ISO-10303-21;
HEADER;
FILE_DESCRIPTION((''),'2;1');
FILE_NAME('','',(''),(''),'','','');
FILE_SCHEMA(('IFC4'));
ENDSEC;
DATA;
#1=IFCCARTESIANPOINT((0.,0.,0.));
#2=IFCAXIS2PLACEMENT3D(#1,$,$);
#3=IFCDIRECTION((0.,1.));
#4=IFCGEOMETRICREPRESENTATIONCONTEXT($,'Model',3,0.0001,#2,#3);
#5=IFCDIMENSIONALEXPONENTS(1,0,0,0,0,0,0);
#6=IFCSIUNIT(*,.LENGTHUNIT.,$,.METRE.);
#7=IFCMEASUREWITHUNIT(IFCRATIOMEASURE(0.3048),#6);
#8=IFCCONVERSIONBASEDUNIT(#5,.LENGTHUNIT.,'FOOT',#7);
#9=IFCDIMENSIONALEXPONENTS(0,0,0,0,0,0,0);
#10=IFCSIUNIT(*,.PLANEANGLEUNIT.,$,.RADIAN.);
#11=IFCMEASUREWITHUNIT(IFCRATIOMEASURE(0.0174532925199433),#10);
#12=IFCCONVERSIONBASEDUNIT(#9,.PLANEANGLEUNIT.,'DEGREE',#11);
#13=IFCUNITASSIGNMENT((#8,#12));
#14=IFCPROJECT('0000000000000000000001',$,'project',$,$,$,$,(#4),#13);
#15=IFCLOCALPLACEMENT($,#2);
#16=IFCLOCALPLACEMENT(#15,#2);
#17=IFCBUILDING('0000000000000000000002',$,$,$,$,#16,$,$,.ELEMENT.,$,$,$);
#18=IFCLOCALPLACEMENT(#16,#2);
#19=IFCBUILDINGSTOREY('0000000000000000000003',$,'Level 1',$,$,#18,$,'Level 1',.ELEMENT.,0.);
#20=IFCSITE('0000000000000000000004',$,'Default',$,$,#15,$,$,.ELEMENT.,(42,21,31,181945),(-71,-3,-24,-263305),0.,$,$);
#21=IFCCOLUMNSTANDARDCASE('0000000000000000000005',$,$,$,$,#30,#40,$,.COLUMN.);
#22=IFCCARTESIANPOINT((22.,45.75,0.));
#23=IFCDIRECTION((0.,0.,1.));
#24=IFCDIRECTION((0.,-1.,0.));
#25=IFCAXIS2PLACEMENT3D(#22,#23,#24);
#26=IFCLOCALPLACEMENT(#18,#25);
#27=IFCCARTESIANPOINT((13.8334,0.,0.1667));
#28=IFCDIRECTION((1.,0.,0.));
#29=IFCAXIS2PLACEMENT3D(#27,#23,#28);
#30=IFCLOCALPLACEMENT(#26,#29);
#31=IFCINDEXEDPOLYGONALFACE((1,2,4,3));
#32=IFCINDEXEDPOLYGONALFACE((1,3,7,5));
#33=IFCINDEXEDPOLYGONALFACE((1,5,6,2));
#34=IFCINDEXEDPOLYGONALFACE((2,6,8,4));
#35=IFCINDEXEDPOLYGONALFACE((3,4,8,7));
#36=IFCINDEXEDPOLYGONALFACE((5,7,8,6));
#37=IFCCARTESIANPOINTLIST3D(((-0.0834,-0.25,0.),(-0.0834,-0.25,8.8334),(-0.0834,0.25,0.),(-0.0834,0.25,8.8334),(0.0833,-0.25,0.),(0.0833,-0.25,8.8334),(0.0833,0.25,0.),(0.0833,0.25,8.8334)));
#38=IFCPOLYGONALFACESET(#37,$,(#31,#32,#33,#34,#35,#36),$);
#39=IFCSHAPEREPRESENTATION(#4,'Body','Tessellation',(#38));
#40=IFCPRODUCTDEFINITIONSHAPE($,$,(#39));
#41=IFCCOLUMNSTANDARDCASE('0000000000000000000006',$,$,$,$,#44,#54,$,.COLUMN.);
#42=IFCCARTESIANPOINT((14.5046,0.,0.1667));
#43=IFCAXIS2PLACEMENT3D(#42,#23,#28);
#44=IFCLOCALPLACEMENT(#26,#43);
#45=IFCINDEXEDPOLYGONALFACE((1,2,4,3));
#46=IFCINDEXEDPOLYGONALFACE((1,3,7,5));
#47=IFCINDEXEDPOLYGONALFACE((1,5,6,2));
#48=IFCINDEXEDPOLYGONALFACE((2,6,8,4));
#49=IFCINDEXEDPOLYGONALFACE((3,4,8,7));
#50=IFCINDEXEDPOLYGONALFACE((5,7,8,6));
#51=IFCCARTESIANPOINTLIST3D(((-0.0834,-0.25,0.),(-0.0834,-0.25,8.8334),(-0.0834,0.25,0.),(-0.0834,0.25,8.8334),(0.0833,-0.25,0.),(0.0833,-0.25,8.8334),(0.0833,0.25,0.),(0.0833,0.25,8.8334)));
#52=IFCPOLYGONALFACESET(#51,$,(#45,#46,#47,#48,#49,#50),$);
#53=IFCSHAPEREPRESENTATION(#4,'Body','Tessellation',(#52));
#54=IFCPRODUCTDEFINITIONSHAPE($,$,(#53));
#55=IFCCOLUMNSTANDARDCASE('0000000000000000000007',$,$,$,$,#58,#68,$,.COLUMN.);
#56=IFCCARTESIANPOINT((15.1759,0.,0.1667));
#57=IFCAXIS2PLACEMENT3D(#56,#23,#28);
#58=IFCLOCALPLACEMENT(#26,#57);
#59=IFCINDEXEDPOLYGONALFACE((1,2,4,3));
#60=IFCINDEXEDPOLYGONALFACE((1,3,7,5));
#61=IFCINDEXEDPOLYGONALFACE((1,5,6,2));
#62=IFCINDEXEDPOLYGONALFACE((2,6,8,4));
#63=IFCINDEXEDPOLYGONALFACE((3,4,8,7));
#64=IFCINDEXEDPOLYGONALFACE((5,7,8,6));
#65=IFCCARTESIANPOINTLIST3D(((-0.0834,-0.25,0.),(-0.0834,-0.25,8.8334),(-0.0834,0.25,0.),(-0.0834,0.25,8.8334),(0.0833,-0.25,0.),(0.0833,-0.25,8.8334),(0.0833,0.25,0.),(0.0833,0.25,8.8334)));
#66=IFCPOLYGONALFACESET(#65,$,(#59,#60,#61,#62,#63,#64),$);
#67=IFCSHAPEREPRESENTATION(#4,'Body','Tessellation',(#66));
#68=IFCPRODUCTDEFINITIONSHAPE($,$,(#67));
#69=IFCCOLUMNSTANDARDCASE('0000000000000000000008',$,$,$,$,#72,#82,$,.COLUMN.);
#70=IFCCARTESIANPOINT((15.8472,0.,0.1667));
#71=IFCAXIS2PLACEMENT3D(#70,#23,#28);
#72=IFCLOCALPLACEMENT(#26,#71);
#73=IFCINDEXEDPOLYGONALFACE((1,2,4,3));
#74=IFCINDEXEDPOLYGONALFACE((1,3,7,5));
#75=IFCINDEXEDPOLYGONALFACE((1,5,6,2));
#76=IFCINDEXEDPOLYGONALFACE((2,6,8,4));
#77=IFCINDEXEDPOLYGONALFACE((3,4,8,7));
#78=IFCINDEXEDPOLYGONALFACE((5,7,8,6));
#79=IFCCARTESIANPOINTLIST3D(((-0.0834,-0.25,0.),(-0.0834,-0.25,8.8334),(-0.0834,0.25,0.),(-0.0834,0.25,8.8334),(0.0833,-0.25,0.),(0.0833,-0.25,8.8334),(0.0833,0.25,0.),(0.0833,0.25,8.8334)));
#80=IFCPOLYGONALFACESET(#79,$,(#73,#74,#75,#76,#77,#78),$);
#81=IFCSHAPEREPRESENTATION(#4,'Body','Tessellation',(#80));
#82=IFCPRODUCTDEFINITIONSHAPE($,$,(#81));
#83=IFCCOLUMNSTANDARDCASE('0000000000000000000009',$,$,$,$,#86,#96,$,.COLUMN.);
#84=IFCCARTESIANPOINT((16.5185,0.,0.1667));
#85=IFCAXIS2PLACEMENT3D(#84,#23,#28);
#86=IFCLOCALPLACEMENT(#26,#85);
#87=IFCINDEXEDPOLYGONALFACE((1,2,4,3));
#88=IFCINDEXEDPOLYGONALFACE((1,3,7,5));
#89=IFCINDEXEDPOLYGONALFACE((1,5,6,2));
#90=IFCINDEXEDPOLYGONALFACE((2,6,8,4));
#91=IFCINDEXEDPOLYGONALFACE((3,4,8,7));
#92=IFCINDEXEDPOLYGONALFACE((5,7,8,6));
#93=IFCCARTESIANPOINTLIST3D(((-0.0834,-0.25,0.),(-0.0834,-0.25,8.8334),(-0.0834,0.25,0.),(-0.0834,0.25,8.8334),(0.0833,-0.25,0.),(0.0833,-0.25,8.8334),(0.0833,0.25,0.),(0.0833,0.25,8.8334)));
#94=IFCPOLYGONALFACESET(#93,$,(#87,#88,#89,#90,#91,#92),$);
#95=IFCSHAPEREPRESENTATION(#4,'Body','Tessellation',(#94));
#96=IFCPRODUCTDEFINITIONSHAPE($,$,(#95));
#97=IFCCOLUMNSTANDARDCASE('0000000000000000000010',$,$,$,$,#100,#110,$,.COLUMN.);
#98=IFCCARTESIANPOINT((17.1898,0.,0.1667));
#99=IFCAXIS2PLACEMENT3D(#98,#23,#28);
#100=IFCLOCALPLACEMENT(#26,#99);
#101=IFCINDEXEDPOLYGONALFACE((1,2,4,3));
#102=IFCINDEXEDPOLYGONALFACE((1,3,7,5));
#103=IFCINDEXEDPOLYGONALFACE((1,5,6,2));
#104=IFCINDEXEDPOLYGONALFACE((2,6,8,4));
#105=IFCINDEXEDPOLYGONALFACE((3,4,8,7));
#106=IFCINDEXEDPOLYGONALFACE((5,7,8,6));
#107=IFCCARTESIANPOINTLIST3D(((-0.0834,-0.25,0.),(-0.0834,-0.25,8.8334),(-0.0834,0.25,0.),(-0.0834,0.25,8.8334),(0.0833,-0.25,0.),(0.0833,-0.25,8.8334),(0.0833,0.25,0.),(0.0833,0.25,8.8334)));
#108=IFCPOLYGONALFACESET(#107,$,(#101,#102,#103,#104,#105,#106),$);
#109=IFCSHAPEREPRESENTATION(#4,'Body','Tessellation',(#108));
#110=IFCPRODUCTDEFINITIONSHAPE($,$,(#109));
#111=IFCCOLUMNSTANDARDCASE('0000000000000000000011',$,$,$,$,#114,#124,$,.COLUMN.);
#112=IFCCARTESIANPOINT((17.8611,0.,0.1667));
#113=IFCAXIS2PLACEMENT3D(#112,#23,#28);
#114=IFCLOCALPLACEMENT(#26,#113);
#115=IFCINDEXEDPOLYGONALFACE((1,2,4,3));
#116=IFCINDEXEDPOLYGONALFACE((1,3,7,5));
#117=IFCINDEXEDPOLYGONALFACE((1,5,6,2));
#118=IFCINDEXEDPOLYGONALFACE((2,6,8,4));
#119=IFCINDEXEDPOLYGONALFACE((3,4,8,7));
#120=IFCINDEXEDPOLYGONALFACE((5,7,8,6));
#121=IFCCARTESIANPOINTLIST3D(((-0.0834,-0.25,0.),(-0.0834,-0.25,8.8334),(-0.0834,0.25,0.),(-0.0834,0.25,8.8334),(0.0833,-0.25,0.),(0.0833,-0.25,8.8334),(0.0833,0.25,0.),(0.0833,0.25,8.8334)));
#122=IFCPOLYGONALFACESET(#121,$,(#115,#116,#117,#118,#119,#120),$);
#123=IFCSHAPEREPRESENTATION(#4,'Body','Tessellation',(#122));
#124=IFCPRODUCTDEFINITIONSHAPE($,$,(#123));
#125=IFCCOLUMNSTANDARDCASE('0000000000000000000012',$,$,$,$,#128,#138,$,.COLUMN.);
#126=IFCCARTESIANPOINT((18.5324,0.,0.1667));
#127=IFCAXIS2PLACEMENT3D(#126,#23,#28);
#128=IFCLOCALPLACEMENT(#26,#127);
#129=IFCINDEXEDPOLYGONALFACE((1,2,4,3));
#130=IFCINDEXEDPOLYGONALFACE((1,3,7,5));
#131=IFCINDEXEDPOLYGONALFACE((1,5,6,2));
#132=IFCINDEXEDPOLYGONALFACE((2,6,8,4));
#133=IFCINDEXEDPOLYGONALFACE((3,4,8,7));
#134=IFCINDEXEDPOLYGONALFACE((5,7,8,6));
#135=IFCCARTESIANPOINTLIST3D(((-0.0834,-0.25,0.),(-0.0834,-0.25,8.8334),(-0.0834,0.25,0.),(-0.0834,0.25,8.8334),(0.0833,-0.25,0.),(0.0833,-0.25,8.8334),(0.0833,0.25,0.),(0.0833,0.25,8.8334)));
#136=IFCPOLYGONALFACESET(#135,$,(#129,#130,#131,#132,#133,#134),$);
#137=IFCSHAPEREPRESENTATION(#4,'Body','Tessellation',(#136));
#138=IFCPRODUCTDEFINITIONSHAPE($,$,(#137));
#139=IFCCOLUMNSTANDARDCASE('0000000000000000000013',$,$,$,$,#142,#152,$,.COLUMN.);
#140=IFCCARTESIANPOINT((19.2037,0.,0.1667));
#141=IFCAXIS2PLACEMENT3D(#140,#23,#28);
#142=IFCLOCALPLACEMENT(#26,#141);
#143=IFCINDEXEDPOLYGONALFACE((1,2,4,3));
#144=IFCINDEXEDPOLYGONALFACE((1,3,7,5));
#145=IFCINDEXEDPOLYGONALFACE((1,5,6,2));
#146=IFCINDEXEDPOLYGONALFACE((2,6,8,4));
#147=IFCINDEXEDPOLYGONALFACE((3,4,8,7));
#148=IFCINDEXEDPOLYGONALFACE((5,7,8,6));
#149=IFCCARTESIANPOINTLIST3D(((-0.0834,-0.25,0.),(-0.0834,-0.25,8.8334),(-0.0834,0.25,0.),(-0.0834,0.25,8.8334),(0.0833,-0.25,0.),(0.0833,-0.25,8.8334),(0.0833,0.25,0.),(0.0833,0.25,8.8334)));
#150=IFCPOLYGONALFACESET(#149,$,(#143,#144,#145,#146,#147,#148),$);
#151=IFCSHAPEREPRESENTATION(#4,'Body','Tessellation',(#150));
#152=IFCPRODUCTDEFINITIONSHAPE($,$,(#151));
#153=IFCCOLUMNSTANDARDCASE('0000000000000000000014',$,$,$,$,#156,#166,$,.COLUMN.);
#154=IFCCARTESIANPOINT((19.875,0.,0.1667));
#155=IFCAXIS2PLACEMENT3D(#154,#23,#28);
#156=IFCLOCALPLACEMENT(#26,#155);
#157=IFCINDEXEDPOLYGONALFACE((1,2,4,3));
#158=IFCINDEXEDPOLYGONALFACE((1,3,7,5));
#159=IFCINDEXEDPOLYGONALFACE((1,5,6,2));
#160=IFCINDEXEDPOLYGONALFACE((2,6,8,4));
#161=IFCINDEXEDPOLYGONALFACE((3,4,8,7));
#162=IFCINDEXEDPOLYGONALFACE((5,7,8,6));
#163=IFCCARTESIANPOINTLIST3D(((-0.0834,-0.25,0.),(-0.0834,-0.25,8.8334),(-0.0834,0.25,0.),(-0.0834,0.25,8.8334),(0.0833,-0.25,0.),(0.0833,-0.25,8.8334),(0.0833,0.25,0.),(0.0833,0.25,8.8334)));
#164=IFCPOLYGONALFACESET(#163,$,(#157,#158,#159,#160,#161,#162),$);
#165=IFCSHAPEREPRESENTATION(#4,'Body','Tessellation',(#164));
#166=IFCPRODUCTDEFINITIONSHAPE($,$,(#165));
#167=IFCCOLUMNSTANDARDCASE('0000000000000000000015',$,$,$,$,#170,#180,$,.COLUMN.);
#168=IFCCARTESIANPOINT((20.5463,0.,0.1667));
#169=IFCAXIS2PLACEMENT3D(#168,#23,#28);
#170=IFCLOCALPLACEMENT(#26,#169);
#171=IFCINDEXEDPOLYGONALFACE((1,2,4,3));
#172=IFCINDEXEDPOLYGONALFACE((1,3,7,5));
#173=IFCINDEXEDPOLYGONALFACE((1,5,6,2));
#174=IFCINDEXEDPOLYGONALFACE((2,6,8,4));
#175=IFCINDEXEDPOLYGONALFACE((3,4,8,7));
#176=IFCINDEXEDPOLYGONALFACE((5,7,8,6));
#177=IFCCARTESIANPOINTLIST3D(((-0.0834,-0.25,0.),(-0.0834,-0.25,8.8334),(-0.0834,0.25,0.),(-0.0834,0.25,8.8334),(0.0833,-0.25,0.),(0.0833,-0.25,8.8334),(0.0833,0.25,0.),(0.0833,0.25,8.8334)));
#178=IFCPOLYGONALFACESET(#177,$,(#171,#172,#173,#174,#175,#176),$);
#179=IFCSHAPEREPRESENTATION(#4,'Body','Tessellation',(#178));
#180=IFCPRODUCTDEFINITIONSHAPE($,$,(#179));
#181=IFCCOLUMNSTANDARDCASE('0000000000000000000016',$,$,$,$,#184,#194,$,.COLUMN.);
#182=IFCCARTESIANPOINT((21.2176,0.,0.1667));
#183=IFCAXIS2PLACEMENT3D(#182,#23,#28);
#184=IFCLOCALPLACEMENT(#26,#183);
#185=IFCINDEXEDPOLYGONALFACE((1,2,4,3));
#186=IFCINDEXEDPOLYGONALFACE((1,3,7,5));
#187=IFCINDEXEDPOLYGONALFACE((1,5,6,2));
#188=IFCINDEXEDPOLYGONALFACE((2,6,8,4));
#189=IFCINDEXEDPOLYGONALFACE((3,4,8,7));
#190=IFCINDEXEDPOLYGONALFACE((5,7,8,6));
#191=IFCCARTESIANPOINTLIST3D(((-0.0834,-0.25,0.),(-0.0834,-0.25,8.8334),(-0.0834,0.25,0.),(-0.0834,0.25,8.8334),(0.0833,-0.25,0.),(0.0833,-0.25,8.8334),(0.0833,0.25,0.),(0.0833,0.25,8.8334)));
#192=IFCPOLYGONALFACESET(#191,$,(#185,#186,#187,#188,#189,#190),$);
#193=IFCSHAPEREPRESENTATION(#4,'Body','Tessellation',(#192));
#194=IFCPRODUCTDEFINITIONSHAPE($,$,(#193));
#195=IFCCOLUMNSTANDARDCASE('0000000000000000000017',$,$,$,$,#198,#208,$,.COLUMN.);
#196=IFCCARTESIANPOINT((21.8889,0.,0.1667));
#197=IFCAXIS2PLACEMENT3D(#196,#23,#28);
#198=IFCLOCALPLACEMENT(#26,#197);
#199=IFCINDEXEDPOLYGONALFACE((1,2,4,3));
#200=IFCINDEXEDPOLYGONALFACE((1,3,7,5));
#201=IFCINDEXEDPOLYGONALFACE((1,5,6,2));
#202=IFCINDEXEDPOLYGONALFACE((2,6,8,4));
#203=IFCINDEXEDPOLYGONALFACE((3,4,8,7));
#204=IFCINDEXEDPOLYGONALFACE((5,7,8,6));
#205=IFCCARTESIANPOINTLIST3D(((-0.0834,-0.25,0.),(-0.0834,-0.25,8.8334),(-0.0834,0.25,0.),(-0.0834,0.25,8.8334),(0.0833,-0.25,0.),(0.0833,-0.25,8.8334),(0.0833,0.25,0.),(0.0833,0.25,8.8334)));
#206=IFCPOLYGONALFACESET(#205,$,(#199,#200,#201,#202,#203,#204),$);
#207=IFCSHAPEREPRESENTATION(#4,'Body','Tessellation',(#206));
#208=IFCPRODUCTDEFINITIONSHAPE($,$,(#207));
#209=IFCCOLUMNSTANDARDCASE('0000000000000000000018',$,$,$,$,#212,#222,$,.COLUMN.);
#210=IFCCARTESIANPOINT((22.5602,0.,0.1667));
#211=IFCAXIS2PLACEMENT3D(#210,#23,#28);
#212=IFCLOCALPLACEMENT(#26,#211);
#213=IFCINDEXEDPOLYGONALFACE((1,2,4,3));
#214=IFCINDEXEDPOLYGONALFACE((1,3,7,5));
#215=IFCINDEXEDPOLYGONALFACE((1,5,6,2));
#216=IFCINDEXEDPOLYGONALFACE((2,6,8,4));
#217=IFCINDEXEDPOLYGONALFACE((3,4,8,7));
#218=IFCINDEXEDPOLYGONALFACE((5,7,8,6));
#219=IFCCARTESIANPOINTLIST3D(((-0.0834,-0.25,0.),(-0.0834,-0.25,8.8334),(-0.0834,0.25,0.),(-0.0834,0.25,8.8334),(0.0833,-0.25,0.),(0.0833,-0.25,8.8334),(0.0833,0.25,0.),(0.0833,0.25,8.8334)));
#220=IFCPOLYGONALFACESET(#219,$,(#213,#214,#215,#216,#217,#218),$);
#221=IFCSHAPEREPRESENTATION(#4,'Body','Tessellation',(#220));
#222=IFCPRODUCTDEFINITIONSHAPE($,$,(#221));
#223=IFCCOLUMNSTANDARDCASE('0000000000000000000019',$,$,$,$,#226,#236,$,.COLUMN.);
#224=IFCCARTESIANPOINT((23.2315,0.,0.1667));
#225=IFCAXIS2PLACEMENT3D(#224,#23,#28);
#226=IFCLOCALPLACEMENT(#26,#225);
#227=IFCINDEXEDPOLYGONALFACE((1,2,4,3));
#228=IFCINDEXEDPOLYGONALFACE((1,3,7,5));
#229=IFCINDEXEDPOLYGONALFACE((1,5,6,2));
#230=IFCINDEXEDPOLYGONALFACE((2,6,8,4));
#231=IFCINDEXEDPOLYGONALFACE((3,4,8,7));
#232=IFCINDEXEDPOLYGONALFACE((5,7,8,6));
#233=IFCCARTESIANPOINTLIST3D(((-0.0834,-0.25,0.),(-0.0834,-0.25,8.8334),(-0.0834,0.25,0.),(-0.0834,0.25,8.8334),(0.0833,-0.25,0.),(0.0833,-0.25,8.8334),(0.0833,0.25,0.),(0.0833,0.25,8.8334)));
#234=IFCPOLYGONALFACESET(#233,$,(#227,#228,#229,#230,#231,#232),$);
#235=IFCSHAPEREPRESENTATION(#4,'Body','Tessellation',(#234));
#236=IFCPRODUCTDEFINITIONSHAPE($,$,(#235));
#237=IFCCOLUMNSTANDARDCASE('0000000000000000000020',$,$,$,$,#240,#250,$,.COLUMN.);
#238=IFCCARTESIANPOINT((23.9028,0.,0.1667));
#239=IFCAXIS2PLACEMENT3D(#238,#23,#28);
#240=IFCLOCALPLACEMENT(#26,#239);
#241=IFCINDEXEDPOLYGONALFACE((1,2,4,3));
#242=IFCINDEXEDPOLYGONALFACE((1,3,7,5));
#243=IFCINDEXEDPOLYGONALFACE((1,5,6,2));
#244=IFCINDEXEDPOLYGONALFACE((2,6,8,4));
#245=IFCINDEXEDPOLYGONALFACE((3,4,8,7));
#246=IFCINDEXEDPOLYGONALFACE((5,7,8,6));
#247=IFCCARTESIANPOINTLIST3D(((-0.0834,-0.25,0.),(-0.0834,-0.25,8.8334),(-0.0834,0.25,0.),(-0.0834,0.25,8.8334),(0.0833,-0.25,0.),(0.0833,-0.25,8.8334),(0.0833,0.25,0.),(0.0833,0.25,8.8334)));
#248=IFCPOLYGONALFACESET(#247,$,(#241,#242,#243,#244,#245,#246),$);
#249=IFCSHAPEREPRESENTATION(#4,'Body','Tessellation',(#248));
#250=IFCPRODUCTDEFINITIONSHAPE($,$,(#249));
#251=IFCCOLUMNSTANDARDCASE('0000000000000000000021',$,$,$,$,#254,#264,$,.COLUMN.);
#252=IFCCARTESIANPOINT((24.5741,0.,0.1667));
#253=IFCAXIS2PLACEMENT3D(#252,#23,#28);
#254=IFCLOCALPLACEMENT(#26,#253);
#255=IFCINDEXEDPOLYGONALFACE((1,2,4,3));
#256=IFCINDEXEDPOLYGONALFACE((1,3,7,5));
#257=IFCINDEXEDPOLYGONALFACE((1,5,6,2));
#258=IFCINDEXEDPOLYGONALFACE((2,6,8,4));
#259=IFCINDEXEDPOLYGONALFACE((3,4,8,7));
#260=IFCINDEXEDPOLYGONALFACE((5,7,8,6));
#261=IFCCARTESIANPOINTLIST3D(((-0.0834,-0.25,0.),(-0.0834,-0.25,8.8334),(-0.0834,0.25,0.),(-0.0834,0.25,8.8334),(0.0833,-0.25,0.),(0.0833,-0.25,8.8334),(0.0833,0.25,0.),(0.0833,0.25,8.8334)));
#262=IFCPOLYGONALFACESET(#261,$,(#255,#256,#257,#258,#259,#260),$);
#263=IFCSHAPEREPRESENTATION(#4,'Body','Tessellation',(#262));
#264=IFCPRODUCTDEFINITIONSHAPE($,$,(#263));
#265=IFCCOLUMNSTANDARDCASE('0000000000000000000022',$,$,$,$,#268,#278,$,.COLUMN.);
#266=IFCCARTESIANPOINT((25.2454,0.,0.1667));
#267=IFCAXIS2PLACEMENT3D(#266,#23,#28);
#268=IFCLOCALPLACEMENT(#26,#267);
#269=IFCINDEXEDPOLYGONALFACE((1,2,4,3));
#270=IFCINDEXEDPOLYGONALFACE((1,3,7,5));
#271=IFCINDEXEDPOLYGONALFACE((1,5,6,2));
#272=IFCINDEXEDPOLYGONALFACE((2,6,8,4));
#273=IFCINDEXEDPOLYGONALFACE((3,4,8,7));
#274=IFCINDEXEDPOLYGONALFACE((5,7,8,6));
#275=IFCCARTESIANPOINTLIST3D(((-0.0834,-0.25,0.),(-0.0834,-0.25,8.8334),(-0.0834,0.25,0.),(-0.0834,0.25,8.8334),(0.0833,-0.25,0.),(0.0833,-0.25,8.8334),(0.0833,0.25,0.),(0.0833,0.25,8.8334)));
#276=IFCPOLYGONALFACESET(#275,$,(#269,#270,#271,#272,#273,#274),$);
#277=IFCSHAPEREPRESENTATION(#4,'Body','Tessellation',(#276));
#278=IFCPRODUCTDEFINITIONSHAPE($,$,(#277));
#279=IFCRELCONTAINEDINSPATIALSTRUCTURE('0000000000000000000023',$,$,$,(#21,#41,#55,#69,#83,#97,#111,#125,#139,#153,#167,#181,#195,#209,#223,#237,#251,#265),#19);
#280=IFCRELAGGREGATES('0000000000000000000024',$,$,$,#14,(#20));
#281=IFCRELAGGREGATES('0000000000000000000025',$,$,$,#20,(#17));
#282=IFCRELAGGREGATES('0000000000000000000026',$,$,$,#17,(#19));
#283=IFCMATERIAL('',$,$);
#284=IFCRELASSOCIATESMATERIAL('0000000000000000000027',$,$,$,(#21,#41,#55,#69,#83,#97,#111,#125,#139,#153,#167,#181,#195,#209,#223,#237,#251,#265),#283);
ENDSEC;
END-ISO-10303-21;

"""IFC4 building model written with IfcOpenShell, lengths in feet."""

from ifc_helpers import new_model, entity, si_unit, converted_unit, direction, frame, origin, place, context, project, spatial, rectangle, extrude, material, element, save


model = new_model("IFC4")

# Units and contexts
model_context = context("Model", 3, precision=0.0001, world=origin(), true_north=direction((0.0, 1.0)))
ifc_project = project(units=[converted_unit("LENGTHUNIT", "FOOT", entity("IfcRatioMeasure", 0.3048), si_unit("LENGTHUNIT", "METRE"), dimensions=[1, 0, 0, 0, 0, 0, 0]), converted_unit("PLANEANGLEUNIT", "DEGREE", entity("IfcRatioMeasure", 0.0174532925199433), si_unit("PLANEANGLEUNIT", "RADIAN"), dimensions=[0, 0, 0, 0, 0, 0, 0])], contexts=[model_context])

# Site, building, storey
site_placement = place(None, origin())
site = spatial("IfcSite", under=ifc_project, at=site_placement, Name="Default", CompositionType="ELEMENT", RefLatitude=(42, 21, 31, 181945), RefLongitude=(-71, -3, -24, -263305), RefElevation=0.0)
building_placement = place(site_placement, origin())
building = spatial("IfcBuilding", under=site, at=building_placement, CompositionType="ELEMENT")
storey_placement = place(building_placement, origin())
storey = spatial("IfcBuildingStorey", under=building, at=storey_placement, Name="Level 1", LongName="Level 1", CompositionType="ELEMENT", Elevation=0.0)

# Columns
ifc_material_1 = material(Name="")
placement_1 = place(storey_placement, frame((22.0, 45.75, 0.0), z_axis=(0.0, 0.0, 1.0), x_axis=(0.0, -1.0, 0.0)))
for number, where, z_axis, x_axis in (
    (1, (13.8334, 0.0, 0.1667), (0.0, 0.0, 1.0), (1.0, 0.0, 0.0)),
    (2, (14.5046, 0.0, 0.1667), (0.0, 0.0, 1.0), (1.0, 0.0, 0.0)),
    (3, (15.1759, 0.0, 0.1667), (0.0, 0.0, 1.0), (1.0, 0.0, 0.0)),
    (4, (15.8472, 0.0, 0.1667), (0.0, 0.0, 1.0), (1.0, 0.0, 0.0)),
    (5, (16.5185, 0.0, 0.1667), (0.0, 0.0, 1.0), (1.0, 0.0, 0.0)),
    (6, (17.1898, 0.0, 0.1667), (0.0, 0.0, 1.0), (1.0, 0.0, 0.0)),
    (7, (17.8611, 0.0, 0.1667), (0.0, 0.0, 1.0), (1.0, 0.0, 0.0)),
    (8, (18.5324, 0.0, 0.1667), (0.0, 0.0, 1.0), (1.0, 0.0, 0.0)),
    (9, (19.2037, 0.0, 0.1667), (0.0, 0.0, 1.0), (1.0, 0.0, 0.0)),
    (10, (19.875, 0.0, 0.1667), (0.0, 0.0, 1.0), (1.0, 0.0, 0.0)),
    (11, (20.5463, 0.0, 0.1667), (0.0, 0.0, 1.0), (1.0, 0.0, 0.0)),
    (12, (21.2176, 0.0, 0.1667), (0.0, 0.0, 1.0), (1.0, 0.0, 0.0)),
    (13, (21.8889, 0.0, 0.1667), (0.0, 0.0, 1.0), (1.0, 0.0, 0.0)),
    (14, (22.5602, 0.0, 0.1667), (0.0, 0.0, 1.0), (1.0, 0.0, 0.0)),
    (15, (23.2315, 0.0, 0.1667), (0.0, 0.0, 1.0), (1.0, 0.0, 0.0)),
    (16, (23.9028, 0.0, 0.1667), (0.0, 0.0, 1.0), (1.0, 0.0, 0.0)),
    (17, (24.5741, 0.0, 0.1667), (0.0, 0.0, 1.0), (1.0, 0.0, 0.0)),
    (18, (25.2454, 0.0, 0.1667), (0.0, 0.0, 1.0), (1.0, 0.0, 0.0)),
):
    element("IfcColumnStandardCase", number, at=place(placement_1, frame(where, z_axis=z_axis, x_axis=x_axis)), inside=storey, material=ifc_material_1, PredefinedType="COLUMN", context=model_context, shape_type="SweptSolid", body=[
        extrude(rectangle(XDim=0.1667, YDim=0.5), origin(), (0.0, 0.0, 1.0), 8.8334),
    ])

save(model, "model.ifc")
